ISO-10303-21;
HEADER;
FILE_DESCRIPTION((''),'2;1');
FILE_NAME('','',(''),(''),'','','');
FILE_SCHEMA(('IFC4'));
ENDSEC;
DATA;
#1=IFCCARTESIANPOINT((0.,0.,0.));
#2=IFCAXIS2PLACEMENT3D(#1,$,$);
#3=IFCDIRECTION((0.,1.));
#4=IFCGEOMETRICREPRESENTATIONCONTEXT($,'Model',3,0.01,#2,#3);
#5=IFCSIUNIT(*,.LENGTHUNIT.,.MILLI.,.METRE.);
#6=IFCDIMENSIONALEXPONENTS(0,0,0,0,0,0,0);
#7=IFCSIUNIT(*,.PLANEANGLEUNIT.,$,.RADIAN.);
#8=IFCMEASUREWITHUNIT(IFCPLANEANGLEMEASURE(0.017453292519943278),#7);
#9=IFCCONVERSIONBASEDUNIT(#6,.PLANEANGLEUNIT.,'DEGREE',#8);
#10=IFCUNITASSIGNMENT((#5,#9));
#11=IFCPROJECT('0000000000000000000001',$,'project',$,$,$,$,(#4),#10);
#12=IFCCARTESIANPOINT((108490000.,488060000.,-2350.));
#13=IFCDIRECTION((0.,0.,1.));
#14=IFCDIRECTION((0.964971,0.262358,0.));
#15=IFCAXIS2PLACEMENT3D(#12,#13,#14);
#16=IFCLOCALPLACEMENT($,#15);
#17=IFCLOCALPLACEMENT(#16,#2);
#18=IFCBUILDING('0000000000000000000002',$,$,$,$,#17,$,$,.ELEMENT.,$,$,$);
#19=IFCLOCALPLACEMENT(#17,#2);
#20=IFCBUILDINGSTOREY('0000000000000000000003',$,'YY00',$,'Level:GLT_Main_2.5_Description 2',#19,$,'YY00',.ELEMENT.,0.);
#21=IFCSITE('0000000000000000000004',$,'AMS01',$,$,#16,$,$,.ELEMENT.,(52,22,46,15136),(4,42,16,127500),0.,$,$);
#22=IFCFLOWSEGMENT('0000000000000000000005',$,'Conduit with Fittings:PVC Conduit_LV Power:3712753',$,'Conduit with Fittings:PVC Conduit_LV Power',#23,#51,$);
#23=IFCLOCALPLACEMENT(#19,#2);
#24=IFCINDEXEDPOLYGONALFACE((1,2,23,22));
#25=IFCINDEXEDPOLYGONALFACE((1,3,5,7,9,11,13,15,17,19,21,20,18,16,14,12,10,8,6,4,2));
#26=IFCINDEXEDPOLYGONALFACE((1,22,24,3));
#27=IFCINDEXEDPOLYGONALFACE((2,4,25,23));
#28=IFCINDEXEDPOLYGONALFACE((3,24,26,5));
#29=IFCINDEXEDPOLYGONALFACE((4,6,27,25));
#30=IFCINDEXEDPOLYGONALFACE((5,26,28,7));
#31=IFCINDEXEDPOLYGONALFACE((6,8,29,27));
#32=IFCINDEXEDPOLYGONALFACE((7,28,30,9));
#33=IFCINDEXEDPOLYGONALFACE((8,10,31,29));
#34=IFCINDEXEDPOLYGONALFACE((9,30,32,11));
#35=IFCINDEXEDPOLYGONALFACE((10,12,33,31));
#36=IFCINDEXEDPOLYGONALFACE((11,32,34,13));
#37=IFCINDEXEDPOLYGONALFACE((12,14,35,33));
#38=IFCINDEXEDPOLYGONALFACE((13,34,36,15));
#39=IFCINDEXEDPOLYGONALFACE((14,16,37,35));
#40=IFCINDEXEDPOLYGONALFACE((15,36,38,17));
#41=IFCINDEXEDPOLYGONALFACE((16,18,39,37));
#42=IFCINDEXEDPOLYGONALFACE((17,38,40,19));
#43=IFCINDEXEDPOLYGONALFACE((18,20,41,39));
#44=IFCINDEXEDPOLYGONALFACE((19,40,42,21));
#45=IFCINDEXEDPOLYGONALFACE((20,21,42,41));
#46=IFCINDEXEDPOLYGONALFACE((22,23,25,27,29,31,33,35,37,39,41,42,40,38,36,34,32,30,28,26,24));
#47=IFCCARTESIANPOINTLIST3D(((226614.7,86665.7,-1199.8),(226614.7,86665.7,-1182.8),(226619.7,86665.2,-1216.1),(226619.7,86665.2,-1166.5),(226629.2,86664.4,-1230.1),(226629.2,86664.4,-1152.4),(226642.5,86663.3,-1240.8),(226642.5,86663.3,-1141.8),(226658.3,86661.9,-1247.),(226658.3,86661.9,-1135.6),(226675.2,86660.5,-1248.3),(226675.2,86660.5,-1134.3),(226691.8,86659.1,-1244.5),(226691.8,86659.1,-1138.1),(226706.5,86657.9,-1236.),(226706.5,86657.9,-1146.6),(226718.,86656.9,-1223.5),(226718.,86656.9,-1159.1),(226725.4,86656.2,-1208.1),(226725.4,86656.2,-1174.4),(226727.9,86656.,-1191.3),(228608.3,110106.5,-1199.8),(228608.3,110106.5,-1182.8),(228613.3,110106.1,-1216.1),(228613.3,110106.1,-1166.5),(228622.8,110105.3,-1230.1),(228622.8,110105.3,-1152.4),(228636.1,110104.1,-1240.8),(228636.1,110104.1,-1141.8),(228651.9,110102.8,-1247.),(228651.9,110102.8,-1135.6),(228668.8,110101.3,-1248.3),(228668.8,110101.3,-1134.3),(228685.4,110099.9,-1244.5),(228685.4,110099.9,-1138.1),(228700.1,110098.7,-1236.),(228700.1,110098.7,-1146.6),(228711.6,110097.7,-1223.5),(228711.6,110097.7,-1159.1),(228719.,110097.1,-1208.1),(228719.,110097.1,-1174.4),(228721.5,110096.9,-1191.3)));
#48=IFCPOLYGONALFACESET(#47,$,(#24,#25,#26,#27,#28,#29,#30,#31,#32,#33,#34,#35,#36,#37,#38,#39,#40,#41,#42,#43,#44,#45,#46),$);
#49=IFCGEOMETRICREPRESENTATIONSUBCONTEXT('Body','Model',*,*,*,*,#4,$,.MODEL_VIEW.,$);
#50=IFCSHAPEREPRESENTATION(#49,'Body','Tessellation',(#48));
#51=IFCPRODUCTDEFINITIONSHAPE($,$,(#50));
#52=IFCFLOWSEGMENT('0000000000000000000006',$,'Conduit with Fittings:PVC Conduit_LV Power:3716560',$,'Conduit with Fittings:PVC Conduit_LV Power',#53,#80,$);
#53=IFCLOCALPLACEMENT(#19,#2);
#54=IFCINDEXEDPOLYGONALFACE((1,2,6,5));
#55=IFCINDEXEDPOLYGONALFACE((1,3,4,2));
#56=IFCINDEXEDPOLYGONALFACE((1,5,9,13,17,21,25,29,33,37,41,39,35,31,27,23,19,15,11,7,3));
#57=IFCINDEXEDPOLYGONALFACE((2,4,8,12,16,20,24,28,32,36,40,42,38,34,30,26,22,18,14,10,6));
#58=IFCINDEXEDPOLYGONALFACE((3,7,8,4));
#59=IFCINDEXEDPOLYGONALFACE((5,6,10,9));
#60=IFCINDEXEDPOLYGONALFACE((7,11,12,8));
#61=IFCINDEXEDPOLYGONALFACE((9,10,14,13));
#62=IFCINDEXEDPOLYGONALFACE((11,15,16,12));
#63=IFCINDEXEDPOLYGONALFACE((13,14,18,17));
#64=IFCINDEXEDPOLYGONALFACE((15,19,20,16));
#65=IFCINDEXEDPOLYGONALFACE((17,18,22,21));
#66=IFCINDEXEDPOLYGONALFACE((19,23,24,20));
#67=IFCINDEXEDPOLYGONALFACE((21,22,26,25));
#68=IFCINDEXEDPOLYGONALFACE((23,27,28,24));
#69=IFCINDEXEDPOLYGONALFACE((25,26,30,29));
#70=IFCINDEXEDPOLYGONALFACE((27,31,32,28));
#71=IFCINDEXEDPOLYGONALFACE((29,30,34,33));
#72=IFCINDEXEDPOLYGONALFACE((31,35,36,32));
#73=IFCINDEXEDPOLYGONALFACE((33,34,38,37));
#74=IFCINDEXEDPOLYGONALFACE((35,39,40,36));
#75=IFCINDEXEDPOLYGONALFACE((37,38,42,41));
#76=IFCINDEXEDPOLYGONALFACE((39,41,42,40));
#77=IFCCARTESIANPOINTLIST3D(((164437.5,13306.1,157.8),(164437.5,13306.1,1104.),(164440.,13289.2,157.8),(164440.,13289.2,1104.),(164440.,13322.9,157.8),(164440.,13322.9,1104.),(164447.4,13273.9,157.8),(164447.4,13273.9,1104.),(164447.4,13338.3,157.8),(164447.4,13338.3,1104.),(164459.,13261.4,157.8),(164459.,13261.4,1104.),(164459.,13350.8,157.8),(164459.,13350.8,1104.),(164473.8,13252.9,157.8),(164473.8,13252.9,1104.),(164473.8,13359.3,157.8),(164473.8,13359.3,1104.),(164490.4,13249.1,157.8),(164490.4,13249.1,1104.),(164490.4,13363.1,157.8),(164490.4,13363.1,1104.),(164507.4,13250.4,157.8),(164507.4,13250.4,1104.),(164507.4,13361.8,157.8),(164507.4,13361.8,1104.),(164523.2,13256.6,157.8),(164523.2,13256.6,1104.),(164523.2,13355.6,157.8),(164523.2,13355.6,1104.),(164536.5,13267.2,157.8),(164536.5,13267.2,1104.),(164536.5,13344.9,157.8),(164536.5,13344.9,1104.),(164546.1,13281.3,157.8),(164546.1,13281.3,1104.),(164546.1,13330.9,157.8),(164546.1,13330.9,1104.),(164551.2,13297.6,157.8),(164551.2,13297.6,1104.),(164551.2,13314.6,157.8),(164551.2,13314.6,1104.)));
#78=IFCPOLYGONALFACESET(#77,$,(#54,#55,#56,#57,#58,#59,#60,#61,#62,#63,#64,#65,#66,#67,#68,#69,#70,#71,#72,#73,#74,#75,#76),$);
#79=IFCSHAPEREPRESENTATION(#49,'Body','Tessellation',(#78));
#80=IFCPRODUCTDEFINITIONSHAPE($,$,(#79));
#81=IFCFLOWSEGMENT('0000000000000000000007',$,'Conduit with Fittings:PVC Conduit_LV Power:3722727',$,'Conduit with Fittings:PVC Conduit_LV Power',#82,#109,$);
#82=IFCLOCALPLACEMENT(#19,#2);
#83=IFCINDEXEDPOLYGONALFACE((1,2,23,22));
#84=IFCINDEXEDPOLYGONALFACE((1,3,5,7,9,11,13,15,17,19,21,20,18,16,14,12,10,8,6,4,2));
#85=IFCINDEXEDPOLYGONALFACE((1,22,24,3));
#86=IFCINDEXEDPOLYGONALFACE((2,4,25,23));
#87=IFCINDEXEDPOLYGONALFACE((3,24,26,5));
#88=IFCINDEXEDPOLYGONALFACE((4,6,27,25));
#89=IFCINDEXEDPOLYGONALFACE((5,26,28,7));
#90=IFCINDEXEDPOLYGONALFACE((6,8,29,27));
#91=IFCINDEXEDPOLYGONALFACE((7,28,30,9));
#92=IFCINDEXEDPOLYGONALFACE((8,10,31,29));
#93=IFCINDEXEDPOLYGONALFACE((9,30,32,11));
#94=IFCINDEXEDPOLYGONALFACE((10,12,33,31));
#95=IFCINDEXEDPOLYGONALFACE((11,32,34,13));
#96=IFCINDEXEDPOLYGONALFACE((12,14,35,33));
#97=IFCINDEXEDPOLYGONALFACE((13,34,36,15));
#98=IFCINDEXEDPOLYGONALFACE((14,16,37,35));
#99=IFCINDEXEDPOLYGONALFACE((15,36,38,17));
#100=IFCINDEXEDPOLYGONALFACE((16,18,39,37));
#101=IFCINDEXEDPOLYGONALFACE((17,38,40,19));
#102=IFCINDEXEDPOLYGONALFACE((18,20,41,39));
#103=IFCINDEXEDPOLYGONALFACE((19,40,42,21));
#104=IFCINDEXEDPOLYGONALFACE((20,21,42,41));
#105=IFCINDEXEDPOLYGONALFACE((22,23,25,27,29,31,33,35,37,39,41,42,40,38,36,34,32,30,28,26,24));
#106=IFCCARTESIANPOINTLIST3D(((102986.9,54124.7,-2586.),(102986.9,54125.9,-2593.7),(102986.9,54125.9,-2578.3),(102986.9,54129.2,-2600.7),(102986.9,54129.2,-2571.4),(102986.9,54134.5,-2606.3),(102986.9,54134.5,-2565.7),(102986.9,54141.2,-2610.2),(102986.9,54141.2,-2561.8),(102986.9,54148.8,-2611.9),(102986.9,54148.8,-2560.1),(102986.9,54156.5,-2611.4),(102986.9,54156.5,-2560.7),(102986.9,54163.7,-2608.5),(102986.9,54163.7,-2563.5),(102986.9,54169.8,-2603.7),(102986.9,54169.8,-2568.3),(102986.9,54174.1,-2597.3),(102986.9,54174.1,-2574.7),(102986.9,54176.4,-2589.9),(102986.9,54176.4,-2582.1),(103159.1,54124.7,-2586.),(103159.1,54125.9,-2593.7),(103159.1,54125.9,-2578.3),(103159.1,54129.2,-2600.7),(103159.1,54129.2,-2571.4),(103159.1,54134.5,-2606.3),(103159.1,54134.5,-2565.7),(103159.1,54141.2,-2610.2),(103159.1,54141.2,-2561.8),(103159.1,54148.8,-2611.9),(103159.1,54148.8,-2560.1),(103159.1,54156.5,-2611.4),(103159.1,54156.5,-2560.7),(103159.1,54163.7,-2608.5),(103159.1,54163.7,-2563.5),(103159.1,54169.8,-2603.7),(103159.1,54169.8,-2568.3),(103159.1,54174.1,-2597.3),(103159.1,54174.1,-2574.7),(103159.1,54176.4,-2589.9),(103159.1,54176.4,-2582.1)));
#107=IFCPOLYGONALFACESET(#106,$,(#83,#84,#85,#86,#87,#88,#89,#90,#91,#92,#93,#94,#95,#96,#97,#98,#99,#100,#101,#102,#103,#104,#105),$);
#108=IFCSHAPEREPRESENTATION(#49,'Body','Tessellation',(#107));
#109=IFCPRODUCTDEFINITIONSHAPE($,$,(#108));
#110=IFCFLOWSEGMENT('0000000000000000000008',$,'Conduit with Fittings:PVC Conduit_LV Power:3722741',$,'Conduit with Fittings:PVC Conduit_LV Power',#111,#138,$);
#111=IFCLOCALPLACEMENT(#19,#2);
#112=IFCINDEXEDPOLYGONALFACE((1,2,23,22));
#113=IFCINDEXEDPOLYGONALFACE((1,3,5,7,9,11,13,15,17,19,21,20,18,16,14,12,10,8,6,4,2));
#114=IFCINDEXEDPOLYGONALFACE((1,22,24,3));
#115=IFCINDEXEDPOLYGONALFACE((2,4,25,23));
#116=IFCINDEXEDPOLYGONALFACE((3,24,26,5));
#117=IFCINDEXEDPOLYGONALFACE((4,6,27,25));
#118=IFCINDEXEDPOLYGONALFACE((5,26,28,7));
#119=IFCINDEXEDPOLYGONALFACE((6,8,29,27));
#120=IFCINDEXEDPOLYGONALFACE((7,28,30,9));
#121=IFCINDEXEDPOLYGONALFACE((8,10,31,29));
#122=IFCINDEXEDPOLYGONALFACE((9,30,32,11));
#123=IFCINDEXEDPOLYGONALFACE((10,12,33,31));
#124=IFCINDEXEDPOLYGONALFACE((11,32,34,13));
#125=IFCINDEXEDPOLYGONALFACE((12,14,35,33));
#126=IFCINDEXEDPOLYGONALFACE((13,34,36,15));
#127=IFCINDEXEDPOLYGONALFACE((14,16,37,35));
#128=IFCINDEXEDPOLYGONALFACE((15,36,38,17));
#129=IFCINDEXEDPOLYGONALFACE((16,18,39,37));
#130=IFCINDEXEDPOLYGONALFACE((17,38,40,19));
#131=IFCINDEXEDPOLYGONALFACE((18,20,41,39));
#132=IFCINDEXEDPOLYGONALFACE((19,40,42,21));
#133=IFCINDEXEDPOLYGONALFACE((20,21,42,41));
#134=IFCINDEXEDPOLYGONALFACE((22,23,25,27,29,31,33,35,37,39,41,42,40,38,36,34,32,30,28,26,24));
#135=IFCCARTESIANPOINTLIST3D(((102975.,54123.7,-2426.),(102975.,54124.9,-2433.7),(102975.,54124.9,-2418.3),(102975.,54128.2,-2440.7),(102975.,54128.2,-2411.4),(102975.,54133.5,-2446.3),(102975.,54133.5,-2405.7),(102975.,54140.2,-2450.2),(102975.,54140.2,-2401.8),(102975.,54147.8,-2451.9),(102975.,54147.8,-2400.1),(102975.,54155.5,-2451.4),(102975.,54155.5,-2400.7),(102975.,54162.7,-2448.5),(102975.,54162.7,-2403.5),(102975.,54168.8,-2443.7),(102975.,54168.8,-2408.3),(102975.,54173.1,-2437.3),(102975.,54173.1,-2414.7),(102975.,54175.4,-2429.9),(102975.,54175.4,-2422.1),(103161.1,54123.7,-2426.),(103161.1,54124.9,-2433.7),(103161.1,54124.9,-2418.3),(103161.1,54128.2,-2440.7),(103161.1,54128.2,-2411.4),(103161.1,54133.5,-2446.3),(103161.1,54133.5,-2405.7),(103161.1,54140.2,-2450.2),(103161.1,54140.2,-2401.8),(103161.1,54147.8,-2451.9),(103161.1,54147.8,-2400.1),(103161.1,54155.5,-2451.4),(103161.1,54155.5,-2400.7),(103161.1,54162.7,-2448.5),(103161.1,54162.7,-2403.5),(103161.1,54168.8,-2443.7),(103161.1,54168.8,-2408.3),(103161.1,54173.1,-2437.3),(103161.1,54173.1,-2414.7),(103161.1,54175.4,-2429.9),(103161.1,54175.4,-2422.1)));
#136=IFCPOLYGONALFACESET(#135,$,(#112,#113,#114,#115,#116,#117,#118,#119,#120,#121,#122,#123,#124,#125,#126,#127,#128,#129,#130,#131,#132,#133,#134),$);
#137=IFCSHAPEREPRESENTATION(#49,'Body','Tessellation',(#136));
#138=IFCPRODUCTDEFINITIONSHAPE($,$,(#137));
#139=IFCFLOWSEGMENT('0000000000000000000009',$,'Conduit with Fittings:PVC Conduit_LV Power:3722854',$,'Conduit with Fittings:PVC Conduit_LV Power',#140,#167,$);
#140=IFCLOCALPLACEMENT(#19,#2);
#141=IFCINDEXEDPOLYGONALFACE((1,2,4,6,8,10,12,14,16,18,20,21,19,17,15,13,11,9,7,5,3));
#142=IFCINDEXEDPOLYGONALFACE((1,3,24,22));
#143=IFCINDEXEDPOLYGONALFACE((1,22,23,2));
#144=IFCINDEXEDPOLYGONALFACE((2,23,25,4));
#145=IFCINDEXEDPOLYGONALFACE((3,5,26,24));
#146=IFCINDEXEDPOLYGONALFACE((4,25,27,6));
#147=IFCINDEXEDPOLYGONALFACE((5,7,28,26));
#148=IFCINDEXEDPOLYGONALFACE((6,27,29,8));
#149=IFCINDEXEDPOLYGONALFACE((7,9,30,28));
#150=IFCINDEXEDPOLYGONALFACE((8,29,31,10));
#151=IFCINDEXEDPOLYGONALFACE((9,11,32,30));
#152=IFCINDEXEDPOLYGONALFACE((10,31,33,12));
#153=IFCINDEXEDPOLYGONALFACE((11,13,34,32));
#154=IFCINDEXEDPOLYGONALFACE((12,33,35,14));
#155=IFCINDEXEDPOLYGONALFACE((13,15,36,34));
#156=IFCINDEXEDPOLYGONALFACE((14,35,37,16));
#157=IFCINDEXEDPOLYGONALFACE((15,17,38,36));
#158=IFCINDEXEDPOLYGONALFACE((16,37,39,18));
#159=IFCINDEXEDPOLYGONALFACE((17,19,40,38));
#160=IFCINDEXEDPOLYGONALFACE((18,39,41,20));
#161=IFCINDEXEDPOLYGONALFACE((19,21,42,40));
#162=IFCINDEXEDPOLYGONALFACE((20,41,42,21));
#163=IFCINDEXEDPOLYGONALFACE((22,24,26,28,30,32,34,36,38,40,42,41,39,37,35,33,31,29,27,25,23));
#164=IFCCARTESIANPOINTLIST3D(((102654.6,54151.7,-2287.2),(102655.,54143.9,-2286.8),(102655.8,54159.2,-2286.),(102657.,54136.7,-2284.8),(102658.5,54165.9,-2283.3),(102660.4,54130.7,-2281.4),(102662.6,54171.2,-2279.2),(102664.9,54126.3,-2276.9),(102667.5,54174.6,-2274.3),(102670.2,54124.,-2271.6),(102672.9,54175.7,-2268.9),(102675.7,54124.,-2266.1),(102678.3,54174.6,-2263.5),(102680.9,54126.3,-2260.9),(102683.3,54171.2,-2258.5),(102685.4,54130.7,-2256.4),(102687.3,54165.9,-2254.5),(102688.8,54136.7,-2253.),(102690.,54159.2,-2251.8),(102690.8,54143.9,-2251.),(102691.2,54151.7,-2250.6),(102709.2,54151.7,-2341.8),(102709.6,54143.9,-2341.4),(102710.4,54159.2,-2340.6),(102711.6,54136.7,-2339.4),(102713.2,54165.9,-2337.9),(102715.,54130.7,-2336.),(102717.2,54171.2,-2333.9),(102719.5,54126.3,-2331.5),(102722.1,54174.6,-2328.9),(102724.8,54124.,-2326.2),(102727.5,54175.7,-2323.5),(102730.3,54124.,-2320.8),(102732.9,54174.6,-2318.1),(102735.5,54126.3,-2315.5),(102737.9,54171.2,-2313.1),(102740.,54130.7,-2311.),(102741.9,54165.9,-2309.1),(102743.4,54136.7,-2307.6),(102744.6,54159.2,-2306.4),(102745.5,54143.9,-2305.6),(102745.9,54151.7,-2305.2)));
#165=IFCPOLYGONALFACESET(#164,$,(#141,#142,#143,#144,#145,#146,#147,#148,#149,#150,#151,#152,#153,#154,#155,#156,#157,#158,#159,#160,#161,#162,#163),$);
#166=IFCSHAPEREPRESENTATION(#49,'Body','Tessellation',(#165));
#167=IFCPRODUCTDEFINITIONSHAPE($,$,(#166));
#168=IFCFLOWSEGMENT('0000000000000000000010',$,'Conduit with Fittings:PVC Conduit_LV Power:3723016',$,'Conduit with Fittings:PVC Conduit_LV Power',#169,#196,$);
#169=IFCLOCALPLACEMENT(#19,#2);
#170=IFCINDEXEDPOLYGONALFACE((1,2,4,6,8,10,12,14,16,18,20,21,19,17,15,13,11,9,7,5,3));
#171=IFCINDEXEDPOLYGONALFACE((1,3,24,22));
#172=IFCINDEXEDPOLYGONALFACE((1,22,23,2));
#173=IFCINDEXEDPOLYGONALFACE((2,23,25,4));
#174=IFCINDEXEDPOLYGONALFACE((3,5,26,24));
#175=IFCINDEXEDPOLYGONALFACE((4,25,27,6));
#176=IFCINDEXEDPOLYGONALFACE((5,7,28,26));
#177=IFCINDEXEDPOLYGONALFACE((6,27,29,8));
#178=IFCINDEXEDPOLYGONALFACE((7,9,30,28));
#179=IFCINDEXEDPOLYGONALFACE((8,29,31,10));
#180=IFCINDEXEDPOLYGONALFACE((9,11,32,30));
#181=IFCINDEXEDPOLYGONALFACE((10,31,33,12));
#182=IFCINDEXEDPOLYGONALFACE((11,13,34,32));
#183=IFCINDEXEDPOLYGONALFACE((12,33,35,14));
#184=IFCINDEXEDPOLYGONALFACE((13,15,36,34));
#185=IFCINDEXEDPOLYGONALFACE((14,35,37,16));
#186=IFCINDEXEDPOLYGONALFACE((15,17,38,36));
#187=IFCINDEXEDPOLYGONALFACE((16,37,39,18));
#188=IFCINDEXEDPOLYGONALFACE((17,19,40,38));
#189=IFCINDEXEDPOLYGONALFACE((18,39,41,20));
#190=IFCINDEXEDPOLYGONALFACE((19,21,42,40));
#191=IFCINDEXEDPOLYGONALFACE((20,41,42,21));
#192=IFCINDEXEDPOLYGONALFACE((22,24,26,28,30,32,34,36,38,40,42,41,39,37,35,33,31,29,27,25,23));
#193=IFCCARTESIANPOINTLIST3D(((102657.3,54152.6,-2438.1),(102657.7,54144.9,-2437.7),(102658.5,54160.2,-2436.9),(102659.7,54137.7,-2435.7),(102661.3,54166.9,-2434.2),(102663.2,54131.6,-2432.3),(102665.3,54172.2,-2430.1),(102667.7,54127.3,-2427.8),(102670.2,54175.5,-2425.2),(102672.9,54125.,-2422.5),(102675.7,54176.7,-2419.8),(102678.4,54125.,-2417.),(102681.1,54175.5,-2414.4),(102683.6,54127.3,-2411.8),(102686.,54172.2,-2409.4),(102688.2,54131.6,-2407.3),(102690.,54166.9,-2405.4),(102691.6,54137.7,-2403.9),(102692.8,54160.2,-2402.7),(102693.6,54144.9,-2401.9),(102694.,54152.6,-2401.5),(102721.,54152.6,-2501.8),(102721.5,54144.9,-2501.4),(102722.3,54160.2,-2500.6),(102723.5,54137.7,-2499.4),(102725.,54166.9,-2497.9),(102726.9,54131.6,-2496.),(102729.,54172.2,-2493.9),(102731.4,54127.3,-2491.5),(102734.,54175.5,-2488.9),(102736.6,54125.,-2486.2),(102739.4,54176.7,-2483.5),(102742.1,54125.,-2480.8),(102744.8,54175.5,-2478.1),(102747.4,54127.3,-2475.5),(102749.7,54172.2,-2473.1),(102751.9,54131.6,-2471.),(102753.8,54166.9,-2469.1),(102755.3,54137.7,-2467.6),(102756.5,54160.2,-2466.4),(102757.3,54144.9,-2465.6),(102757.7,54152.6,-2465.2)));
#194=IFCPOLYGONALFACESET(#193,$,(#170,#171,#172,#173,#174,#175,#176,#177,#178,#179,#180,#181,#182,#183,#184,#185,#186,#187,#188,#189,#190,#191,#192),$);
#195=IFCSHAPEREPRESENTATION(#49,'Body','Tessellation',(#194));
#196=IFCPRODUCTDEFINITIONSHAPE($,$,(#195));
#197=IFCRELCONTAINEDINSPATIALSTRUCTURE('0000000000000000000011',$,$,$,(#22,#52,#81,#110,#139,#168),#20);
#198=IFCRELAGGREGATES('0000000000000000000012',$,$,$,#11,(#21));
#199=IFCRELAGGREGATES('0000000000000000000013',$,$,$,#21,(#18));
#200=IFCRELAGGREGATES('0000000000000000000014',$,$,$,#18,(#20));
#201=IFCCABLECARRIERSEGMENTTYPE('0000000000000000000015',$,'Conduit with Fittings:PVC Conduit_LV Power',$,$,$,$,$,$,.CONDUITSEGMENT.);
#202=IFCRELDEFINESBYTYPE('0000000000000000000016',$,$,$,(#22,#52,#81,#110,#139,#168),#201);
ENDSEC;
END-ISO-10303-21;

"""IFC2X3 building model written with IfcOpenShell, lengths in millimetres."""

from ifc_helpers import new_model, entity, si_unit, converted_unit, direction, frame, origin, origin_2d_with_axis, place, context, subcontext, project, spatial, circle, extrude, type_object, element, save


model = new_model("IFC2X3")

# Units and contexts
model_context = context("Model", 3, precision=0.01, world=origin(), true_north=direction((0.0, 1.0)))
body_context = subcontext(model_context, "Body", "Model", "MODEL_VIEW")
ifc_project = project(units=[si_unit("LENGTHUNIT", "METRE", prefix="MILLI"), converted_unit("PLANEANGLEUNIT", "DEGREE", entity("IfcPlaneAngleMeasure", 0.017453292519943278), si_unit("PLANEANGLEUNIT", "RADIAN"), dimensions=[0, 0, 0, 0, 0, 0, 0])], contexts=[model_context])

# Site, building, storey
site_placement = place(None, frame((108490000.0, 488060000.0, -2350.0), z_axis=(0.0, 0.0, 1.0), x_axis=(0.964971, 0.262358, 0.0)))
site = spatial("IfcSite", under=ifc_project, at=site_placement, Name="AMS01", CompositionType="ELEMENT", RefLatitude=(52, 22, 46, 15136), RefLongitude=(4, 42, 16, 127500), RefElevation=0.0)
building_placement = place(site_placement, origin())
building = spatial("IfcBuilding", under=site, at=building_placement, CompositionType="ELEMENT")
storey_placement = place(building_placement, origin())
storey = spatial("IfcBuildingStorey", under=building, at=storey_placement, Name="YY00", ObjectType="Level:GLT_Main_2.5_Description 2", LongName="YY00", CompositionType="ELEMENT", Elevation=0.0)

# Flow segments
cable_carrier_segment_type = type_object("IfcCableCarrierSegmentType", Name="Conduit with Fittings:PVC Conduit_LV Power", PredefinedType="CONDUITSEGMENT")
flow_segment_1_placement = place(storey_placement, origin())
element("IfcFlowSegment", 1, at=flow_segment_1_placement, inside=storey, type_object=cable_carrier_segment_type, Name="Conduit with Fittings:PVC Conduit_LV Power:3712753", ObjectType="Conduit with Fittings:PVC Conduit_LV Power", context=body_context, shape_type="SweptSolid", body=[
    extrude(circle(Radius=57.2, at=origin_2d_with_axis()), frame((226671.0, 86660.9, -1191.3), z_axis=(0.084742, 0.996403, 0.0), x_axis=(0.996403, -0.084742, 0.0)), (0.0, 0.0, 1.0), 23525.5),
])
flow_segment_2_placement = place(storey_placement, origin())
element("IfcFlowSegment", 2, at=flow_segment_2_placement, inside=storey, type_object=cable_carrier_segment_type, Name="Conduit with Fittings:PVC Conduit_LV Power:3716560", ObjectType="Conduit with Fittings:PVC Conduit_LV Power", context=body_context, shape_type="SweptSolid", body=[
    extrude(circle(Radius=57.2, at=origin_2d_with_axis()), frame((164494.6, 13306.1, 157.8), z_axis=(0.0, 0.0, 1.0), x_axis=(-1.0, 0.0, 0.0)), (0.0, 0.0, 1.0), 946.2),
])
flow_segment_3_placement = place(storey_placement, origin())
element("IfcFlowSegment", 3, at=flow_segment_3_placement, inside=storey, type_object=cable_carrier_segment_type, Name="Conduit with Fittings:PVC Conduit_LV Power:3722727", ObjectType="Conduit with Fittings:PVC Conduit_LV Power", context=body_context, shape_type="SweptSolid", body=[
    extrude(circle(Radius=26.0, at=origin_2d_with_axis()), frame((102986.9, 54150.7, -2586.0), z_axis=(1.0, 0.0, 0.0), x_axis=(0.0, -1.0, 0.0)), (0.0, 0.0, 1.0), 172.2),
])
flow_segment_4_placement = place(storey_placement, origin())
element("IfcFlowSegment", 4, at=flow_segment_4_placement, inside=storey, type_object=cable_carrier_segment_type, Name="Conduit with Fittings:PVC Conduit_LV Power:3722741", ObjectType="Conduit with Fittings:PVC Conduit_LV Power", context=body_context, shape_type="SweptSolid", body=[
    extrude(circle(Radius=26.0, at=origin_2d_with_axis()), frame((102975.0, 54149.7, -2426.0), z_axis=(1.0, 0.0, 0.0), x_axis=(0.0, -1.0, 0.0)), (0.0, 0.0, 1.0), 186.1),
])
flow_segment_5_placement = place(storey_placement, origin())
element("IfcFlowSegment", 5, at=flow_segment_5_placement, inside=storey, type_object=cable_carrier_segment_type, Name="Conduit with Fittings:PVC Conduit_LV Power:3722854", ObjectType="Conduit with Fittings:PVC Conduit_LV Power", context=body_context, shape_type="SweptSolid", body=[
    extrude(circle(Radius=26.0, at=origin_2d_with_axis()), frame((102672.9, 54149.7, -2268.9), z_axis=(0.707107, 0.0, -0.707107), x_axis=(0.0, 1.0, 0.0)), (0.0, 0.0, 1.0), 77.2),
])
flow_segment_6_placement = place(storey_placement, origin())
element("IfcFlowSegment", 6, at=flow_segment_6_placement, inside=storey, type_object=cable_carrier_segment_type, Name="Conduit with Fittings:PVC Conduit_LV Power:3723016", ObjectType="Conduit with Fittings:PVC Conduit_LV Power", context=body_context, shape_type="SweptSolid", body=[
    extrude(circle(Radius=26.0, at=origin_2d_with_axis()), frame((102675.7, 54150.7, -2419.8), z_axis=(0.707107, 0.0, -0.707107), x_axis=(0.0, 1.0, 0.0)), (0.0, 0.0, 1.0), 90.1),
])

save(model, "model.ifc")
